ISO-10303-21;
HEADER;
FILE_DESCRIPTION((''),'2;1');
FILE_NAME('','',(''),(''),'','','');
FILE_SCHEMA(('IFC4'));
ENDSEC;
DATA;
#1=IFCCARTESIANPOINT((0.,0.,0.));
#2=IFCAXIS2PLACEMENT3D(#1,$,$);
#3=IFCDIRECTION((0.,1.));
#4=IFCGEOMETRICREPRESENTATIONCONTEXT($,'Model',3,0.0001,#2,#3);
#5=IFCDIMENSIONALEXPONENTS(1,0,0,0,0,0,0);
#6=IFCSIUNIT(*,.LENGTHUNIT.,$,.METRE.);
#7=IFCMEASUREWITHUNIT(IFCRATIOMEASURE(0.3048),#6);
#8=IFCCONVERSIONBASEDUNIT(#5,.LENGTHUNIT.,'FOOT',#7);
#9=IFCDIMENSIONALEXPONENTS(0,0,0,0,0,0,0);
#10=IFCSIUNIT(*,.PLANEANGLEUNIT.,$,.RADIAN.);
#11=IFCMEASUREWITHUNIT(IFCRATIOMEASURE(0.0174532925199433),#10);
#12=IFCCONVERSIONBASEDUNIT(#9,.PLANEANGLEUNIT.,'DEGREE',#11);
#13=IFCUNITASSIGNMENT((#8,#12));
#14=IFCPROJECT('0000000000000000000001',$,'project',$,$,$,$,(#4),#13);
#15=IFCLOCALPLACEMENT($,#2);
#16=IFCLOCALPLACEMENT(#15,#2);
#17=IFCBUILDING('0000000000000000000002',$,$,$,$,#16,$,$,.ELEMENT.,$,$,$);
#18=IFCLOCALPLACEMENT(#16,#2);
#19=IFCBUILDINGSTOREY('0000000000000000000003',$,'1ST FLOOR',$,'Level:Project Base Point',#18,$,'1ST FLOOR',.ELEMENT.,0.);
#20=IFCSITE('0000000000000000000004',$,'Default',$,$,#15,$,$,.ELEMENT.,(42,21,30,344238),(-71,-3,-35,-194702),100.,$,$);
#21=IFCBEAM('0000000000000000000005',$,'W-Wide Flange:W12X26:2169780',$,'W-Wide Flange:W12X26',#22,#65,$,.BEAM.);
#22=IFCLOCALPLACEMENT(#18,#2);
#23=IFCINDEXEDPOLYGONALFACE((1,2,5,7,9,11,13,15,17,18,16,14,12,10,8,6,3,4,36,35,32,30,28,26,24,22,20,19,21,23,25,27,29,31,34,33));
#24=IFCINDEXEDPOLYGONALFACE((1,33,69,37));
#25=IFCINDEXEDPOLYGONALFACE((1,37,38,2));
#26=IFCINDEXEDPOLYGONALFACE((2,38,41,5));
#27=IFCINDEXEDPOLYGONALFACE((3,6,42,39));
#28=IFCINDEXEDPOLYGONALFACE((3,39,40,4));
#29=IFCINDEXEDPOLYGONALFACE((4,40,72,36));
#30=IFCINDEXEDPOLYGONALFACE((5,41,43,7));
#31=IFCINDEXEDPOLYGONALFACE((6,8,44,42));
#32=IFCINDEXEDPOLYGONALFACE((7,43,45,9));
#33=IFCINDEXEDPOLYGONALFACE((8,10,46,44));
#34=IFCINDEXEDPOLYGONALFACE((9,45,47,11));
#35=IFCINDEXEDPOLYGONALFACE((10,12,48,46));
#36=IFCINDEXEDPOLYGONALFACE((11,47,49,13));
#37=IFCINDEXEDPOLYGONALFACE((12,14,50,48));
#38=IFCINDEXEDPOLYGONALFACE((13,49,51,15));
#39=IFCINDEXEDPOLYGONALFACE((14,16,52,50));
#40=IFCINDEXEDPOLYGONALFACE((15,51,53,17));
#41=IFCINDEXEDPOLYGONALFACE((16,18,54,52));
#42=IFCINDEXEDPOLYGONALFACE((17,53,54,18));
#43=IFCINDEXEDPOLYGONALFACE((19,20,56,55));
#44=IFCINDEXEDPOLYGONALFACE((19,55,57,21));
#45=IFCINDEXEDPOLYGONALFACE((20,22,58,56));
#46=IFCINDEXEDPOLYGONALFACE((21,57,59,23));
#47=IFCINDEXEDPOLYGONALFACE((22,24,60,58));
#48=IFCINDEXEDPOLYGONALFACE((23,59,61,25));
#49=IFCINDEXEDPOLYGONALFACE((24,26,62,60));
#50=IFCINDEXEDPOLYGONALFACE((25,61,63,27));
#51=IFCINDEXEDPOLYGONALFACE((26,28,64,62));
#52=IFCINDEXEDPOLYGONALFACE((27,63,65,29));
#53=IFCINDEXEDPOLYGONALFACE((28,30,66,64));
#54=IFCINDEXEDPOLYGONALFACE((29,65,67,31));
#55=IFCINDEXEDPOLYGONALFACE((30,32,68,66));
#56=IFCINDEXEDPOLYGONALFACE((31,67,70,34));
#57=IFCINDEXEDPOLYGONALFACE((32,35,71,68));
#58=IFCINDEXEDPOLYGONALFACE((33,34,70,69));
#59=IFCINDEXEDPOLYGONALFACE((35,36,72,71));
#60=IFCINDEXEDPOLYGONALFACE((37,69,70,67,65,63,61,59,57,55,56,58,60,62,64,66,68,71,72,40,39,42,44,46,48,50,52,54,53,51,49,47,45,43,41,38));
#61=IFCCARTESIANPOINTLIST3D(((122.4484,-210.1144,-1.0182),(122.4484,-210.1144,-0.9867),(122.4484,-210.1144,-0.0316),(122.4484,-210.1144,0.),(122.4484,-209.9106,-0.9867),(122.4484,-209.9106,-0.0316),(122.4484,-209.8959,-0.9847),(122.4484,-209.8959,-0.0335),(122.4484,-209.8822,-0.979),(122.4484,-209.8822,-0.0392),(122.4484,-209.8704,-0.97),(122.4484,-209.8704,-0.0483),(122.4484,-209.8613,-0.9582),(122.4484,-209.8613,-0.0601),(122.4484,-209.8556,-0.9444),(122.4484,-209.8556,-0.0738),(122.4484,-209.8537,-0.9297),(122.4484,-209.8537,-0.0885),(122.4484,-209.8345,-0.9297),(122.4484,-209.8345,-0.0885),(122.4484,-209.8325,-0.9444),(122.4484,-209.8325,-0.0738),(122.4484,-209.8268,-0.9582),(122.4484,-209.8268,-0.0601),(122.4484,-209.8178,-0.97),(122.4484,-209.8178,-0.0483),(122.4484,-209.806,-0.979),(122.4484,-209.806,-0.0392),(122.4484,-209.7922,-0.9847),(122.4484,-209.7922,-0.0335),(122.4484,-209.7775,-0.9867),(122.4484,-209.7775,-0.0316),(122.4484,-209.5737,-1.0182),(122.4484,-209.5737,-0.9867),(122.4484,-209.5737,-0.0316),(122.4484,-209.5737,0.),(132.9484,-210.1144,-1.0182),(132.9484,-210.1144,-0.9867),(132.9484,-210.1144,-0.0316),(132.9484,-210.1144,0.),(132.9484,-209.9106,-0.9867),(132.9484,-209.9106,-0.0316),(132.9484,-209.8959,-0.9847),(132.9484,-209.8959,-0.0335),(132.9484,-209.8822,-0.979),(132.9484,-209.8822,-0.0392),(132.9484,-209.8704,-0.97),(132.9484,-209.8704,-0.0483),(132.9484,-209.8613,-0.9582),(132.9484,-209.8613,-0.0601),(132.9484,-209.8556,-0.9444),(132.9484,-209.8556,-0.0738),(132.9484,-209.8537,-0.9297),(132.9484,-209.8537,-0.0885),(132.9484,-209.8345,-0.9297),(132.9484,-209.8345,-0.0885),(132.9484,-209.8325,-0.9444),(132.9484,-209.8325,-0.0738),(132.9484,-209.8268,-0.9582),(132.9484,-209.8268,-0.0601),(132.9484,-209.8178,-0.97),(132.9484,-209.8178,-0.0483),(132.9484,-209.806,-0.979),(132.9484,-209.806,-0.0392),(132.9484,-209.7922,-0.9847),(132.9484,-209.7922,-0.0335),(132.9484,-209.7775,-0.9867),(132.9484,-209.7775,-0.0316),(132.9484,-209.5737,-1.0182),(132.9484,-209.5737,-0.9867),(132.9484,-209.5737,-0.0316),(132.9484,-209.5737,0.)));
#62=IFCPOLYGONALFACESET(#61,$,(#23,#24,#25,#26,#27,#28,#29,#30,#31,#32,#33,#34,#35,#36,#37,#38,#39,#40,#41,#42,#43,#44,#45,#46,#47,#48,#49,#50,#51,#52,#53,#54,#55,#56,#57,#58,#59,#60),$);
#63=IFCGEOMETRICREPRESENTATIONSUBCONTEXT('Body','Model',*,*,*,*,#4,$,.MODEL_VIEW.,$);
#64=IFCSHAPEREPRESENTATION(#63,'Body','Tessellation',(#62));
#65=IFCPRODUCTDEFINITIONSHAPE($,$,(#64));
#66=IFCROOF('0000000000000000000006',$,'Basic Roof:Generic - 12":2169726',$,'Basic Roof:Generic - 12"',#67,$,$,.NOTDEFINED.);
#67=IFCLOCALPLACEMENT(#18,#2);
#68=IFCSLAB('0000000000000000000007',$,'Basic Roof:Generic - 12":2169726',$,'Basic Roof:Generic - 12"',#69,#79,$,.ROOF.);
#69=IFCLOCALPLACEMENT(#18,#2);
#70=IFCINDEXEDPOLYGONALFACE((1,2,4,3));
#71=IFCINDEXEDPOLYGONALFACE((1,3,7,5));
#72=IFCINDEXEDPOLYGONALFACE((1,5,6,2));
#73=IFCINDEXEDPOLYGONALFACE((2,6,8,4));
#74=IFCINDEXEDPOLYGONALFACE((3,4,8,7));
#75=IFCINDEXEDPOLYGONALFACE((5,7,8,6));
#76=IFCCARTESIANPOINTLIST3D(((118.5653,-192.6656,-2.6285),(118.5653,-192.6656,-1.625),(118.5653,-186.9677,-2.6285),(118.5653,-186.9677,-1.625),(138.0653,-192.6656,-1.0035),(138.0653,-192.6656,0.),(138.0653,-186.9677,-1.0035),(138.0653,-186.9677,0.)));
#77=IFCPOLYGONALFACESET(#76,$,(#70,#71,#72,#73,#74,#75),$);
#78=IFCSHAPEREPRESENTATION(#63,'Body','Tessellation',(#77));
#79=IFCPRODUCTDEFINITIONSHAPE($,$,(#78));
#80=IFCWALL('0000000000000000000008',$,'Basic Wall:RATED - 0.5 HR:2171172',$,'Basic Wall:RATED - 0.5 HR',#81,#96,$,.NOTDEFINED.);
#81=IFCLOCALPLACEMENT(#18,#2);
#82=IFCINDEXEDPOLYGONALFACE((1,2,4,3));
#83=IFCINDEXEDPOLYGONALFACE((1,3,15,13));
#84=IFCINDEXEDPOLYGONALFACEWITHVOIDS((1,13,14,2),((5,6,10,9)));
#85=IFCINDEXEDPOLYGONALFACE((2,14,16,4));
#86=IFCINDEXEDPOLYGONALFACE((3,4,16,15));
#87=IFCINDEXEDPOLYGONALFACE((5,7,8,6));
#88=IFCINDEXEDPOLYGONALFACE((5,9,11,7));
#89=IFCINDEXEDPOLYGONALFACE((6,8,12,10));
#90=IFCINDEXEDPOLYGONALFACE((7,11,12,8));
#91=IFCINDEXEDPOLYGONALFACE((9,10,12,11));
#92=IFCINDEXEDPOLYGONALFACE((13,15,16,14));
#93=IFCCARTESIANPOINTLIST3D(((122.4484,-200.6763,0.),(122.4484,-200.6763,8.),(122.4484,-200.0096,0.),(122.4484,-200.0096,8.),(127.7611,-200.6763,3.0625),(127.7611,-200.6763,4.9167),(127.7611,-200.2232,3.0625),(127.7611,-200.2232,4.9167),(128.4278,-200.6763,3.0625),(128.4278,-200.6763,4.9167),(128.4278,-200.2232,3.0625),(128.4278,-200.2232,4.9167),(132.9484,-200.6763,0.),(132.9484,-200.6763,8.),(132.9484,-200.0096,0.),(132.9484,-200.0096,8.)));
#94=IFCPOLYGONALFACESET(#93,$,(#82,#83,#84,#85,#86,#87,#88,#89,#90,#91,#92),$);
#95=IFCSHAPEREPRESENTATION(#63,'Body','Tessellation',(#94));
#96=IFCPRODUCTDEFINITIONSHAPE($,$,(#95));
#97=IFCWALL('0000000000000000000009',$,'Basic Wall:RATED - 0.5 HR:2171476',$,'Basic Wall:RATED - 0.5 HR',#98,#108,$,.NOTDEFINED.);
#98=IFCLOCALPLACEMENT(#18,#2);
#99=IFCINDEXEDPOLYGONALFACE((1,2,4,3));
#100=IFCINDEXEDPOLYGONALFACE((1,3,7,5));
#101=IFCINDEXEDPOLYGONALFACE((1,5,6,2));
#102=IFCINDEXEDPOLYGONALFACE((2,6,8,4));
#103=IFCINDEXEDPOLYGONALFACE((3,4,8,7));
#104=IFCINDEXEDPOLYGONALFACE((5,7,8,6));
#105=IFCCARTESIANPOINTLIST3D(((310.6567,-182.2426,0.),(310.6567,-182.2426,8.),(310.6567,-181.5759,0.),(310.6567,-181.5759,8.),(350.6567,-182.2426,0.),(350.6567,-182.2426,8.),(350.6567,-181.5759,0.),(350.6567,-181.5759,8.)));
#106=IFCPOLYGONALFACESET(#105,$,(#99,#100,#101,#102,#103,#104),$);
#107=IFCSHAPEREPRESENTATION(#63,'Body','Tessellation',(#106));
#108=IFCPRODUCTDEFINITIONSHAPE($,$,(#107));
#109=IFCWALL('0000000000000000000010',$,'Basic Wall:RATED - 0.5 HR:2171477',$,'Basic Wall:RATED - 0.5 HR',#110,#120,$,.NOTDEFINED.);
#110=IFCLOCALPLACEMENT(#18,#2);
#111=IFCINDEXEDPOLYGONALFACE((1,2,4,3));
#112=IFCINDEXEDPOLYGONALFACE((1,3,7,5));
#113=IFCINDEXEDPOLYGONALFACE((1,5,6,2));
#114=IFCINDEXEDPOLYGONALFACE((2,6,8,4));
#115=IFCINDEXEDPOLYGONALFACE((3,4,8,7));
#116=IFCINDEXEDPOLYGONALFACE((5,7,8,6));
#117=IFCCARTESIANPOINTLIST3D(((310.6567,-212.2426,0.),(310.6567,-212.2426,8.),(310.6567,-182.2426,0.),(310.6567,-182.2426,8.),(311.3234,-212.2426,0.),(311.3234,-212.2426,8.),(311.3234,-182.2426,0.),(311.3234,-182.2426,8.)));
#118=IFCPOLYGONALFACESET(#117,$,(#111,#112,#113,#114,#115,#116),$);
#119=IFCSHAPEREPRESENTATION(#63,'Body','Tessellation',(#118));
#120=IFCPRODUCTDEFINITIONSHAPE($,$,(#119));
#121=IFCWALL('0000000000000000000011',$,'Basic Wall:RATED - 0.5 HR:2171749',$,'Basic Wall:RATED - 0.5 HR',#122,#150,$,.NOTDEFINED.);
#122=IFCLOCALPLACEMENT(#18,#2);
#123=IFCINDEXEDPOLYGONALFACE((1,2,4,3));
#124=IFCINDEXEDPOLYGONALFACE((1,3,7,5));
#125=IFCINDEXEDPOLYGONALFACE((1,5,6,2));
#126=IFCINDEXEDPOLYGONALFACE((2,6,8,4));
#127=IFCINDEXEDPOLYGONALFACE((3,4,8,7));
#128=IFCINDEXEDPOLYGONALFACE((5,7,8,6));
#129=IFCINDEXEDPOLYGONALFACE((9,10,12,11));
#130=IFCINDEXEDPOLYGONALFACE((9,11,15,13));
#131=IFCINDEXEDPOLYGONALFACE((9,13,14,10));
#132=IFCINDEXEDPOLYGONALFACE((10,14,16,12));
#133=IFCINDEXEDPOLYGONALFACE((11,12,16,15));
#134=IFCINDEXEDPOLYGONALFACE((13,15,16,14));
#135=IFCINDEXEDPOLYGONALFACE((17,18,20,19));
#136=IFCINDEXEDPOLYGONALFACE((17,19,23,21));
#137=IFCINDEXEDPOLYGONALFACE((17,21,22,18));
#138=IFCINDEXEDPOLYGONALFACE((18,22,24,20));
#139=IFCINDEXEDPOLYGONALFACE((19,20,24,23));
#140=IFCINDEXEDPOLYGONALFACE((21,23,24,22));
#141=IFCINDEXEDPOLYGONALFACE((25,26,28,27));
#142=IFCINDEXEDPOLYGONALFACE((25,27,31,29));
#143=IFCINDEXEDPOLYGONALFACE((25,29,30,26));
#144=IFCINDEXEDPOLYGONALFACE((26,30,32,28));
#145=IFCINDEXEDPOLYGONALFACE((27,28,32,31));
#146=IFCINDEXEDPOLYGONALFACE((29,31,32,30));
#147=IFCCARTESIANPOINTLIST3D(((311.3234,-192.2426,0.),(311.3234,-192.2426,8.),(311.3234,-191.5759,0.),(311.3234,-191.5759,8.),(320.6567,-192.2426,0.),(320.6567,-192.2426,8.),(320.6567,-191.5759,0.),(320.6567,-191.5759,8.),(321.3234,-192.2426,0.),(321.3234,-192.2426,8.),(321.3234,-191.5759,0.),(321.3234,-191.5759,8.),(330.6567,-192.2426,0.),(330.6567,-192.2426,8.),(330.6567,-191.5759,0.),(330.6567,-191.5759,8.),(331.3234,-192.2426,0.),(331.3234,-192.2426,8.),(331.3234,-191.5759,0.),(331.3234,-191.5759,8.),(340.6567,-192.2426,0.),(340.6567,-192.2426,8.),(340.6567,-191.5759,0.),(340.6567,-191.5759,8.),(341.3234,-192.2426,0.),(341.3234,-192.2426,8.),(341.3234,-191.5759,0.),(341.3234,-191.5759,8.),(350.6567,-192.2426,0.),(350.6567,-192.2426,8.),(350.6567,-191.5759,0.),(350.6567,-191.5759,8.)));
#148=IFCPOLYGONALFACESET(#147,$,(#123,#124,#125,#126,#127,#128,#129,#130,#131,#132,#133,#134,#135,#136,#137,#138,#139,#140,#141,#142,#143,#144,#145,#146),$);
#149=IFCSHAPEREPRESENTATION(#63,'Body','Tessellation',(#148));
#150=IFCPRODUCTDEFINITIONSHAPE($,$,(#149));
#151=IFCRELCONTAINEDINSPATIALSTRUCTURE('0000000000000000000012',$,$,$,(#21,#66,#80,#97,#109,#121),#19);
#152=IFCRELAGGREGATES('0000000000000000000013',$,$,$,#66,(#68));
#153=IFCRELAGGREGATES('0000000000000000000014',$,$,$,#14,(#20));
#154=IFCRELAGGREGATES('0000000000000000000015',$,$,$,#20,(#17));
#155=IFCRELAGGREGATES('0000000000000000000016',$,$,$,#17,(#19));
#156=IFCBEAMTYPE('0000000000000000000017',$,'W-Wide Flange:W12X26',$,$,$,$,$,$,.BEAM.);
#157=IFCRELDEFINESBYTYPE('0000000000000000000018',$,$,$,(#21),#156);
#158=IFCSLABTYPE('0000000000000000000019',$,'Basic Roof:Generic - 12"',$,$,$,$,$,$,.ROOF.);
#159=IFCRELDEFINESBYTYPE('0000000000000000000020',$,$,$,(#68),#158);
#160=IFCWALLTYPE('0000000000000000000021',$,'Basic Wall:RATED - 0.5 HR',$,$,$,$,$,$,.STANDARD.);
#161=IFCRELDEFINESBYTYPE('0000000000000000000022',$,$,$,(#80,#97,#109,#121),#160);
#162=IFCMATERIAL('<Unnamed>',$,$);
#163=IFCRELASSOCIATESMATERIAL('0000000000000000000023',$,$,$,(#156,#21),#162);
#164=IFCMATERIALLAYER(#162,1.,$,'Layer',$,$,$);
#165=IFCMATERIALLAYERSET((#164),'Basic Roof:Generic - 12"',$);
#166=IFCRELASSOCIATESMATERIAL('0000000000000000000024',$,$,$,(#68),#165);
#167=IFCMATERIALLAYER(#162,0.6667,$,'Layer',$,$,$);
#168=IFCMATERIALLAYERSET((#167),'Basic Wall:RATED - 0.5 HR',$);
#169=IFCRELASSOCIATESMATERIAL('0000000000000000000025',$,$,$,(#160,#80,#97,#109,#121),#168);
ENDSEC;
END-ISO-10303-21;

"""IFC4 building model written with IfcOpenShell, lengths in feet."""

from ifc_helpers import new_model, entity, si_unit, converted_unit, direction, frame, frame_2d, origin, place, context, subcontext, project, spatial, rectangle, i_section, extrude, source, transform, mapped, material, layer, layer_set, layer_usage, material_profile, profile_set, profile_usage, type_object, type_shapes, element, aggregate, save


model = new_model("IFC4")

# Units and contexts
model_context = context("Model", 3, precision=0.0001, world=origin(), true_north=direction((0.0, 1.0)))
body_context = subcontext(model_context, "Body", "Model", "MODEL_VIEW")
ifc_project = project(units=[converted_unit("LENGTHUNIT", "FOOT", entity("IfcRatioMeasure", 0.3048), si_unit("LENGTHUNIT", "METRE"), dimensions=[1, 0, 0, 0, 0, 0, 0]), converted_unit("PLANEANGLEUNIT", "DEGREE", entity("IfcRatioMeasure", 0.0174532925199433), si_unit("PLANEANGLEUNIT", "RADIAN"), dimensions=[0, 0, 0, 0, 0, 0, 0])], contexts=[model_context])

# Site, building, storey
site_placement = place(None, origin())
site = spatial("IfcSite", under=ifc_project, at=site_placement, Name="Default", CompositionType="ELEMENT", RefLatitude=(42, 21, 30, 344238), RefLongitude=(-71, -3, -35, -194702), RefElevation=100.0)
building_placement = place(site_placement, origin())
building = spatial("IfcBuilding", under=site, at=building_placement, CompositionType="ELEMENT")
storey_placement = place(building_placement, origin())
storey = spatial("IfcBuildingStorey", under=building, at=storey_placement, Name="1ST FLOOR", ObjectType="Level:Project Base Point", LongName="1ST FLOOR", CompositionType="ELEMENT", Elevation=0.0)

# Beam
ifc_material_1 = material(Name="<Unnamed>")
ifc_material_profile = material_profile(ifc_material_1, i_section(OverallWidth=0.5407, OverallDepth=1.0182, WebThickness=0.0192, FlangeThickness=0.0316, FilletRadius=0.057, at=frame_2d((0.0, 0.0), x_axis=(0.0, 1.0))), Name="W12X26")
ifc_profile_set = profile_set([ifc_material_profile], Name="W12X26")
ifc_profile_usage = profile_usage(ifc_profile_set, cardinal=8)
beam_type = type_object("IfcBeamType", Name="W-Wide Flange:W12X26", PredefinedType="BEAM", material=ifc_profile_set)
shared_shape_1 = source(origin(), body_context, "Body", "SweptSolid", [
    extrude(i_section(OverallWidth=0.5407, OverallDepth=1.0182, WebThickness=0.0192, FlangeThickness=0.0316, FilletRadius=0.057, at=frame_2d((0.0, 0.0), x_axis=(0.0, 1.0))), frame((-5.25, 0.0, 0.0), z_axis=(1.0, 0.0, 0.0), x_axis=(0.0, 0.0, -1.0)), (0.0, 0.0, 1.0), 10.5),
])
type_shapes(beam_type, [shared_shape_1])
beam_placement = place(storey_placement, frame((127.6984, -209.8441, -0.5091)))
element("IfcBeam", 1, at=beam_placement, inside=storey, type_object=beam_type, material=ifc_profile_usage, Name="W-Wide Flange:W12X26:2169780", ObjectType="W-Wide Flange:W12X26", PredefinedType="BEAM", context=body_context, shape_type="MappedRepresentation", body=[
    mapped(shared_shape_1, transform((0.0, 0.0, 0.0), scale=1.0)),
])

# Roof, slab
roof_placement = place(storey_placement, frame((118.5653, -192.6656, -2.6285)))
roof = element("IfcRoof", 2, at=roof_placement, inside=storey, Name="Basic Roof:Generic - 12\":2169726", ObjectType="Basic Roof:Generic - 12\"", PredefinedType="NOTDEFINED")
ifc_layer_1 = layer(ifc_material_1, 1.0, Name="Layer")
ifc_layer_set_1 = layer_set([ifc_layer_1], Name="Basic Roof:Generic - 12\"")
slab_type = type_object("IfcSlabType", Name="Basic Roof:Generic - 12\"", PredefinedType="ROOF")
slab_placement = place(roof_placement, origin())
slab = element("IfcSlab", 3, at=slab_placement, type_object=slab_type, material=ifc_layer_set_1, Name="Basic Roof:Generic - 12\":2169726", ObjectType="Basic Roof:Generic - 12\"", PredefinedType="ROOF", context=body_context, shape_type="SweptSolid", body=[
    extrude(rectangle(XDim=19.5676, YDim=5.6979, at=frame_2d((0.0, 0.0), x_axis=(1.0, 0.0))), frame((9.75, 2.849, 0.8125), z_axis=(-0.083045, 0.0, 0.996546), x_axis=(0.996546, 0.0, 0.083045)), (0.083045, 0.0, 0.996546), 1.0035),
])
aggregate(roof, [slab])

# Wall, opening
ifc_layer_2 = layer(ifc_material_1, 0.6667, Name="Layer")
ifc_layer_set_2 = layer_set([ifc_layer_2], Name="Basic Wall:RATED - 0.5 HR")
ifc_layer_usage_1 = layer_usage(ifc_layer_set_2, "AXIS2", "NEGATIVE", 0.3333)
wall_type_1 = type_object("IfcWallType", Name="Basic Wall:RATED - 0.5 HR", PredefinedType="STANDARD", material=ifc_layer_set_2)
wall_1_placement = place(storey_placement, frame((122.4484, -200.3429, 0.0)))
wall_1 = element("IfcWall", 4, at=wall_1_placement, inside=storey, type_object=wall_type_1, material=ifc_layer_usage_1, Name="Basic Wall:RATED - 0.5 HR:2171172", ObjectType="Basic Wall:RATED - 0.5 HR", PredefinedType="NOTDEFINED", context=body_context, shape_type="SweptSolid", body=[
    extrude(rectangle(XDim=10.5, YDim=0.6667, at=frame_2d((5.25, 0.0), x_axis=(-1.0, 0.0))), origin(), (0.0, 0.0, 1.0), 8.0),
])
opening_1_placement = place(wall_1_placement, frame((5.3127, -0.3542, 3.0625)))
element("IfcOpeningElement", 5, at=opening_1_placement, cuts=wall_1, PredefinedType="RECESS", context=body_context, shape_type="SweptSolid", body=[
    extrude(rectangle(XDim=1.8542, YDim=0.6667, at=frame_2d((0.0, 0.0), x_axis=(1.0, 0.0))), frame((0.3333, 0.0, 0.9271), z_axis=(0.0, 1.0, 0.0), x_axis=(0.0, 0.0, -1.0)), (0.0, 0.0, 1.0), 0.474),
])

# Walls
ifc_layer_usage_2 = layer_usage(ifc_layer_set_2, "AXIS2", "NEGATIVE", 0.3333)
wall_2_placement = place(storey_placement, frame((310.6567, -181.9092, 0.0)))
element("IfcWall", 6, at=wall_2_placement, inside=storey, type_object=wall_type_1, material=ifc_layer_usage_2, Name="Basic Wall:RATED - 0.5 HR:2171476", ObjectType="Basic Wall:RATED - 0.5 HR", PredefinedType="NOTDEFINED", context=body_context, shape_type="SweptSolid", body=[
    extrude(rectangle(XDim=40.0, YDim=0.6667, at=frame_2d((20.0, 0.0), x_axis=(-1.0, 0.0))), origin(), (0.0, 0.0, 1.0), 8.0),
])
ifc_layer_usage_3 = layer_usage(ifc_layer_set_2, "AXIS2", "NEGATIVE", 0.3333)
wall_3_placement = place(storey_placement, frame((310.9901, -212.2426, 0.0), z_axis=(0.0, 0.0, 1.0), x_axis=(0.0, 1.0, 0.0)))
element("IfcWall", 7, at=wall_3_placement, inside=storey, type_object=wall_type_1, material=ifc_layer_usage_3, Name="Basic Wall:RATED - 0.5 HR:2171477", ObjectType="Basic Wall:RATED - 0.5 HR", PredefinedType="NOTDEFINED", context=body_context, shape_type="SweptSolid", body=[
    extrude(rectangle(XDim=30.0, YDim=0.6667, at=frame_2d((15.0, 0.0), x_axis=(-1.0, 0.0))), origin(), (0.0, 0.0, 1.0), 8.0),
])

# Wall, openings
ifc_layer_usage_4 = layer_usage(ifc_layer_set_2, "AXIS2", "NEGATIVE", 0.3333)
wall_4_placement = place(storey_placement, frame((311.3234, -191.9092, 0.0)))
wall_4 = element("IfcWall", 8, at=wall_4_placement, inside=storey, type_object=wall_type_1, material=ifc_layer_usage_4, Name="Basic Wall:RATED - 0.5 HR:2171749", ObjectType="Basic Wall:RATED - 0.5 HR", PredefinedType="NOTDEFINED", context=body_context, shape_type="SweptSolid", body=[
    extrude(rectangle(XDim=39.3333, YDim=0.6667, at=frame_2d((19.6667, 0.0), x_axis=(-1.0, 0.0))), origin(), (0.0, 0.0, 1.0), 8.0),
])
opening_2_placement = place(storey_placement, frame((311.3234, -191.9092, 0.0)))
element("IfcOpeningElement", 9, at=opening_2_placement, cuts=wall_4, PredefinedType="OPENING", context=body_context, shape_type="SweptSolid", body=[
    extrude(rectangle(XDim=8.0, YDim=0.6667, at=frame_2d((0.0, 0.0), x_axis=(1.0, 0.0))), frame((29.3333, 0.0, 4.0), z_axis=(1.0, 0.0, 0.0), x_axis=(0.0, 0.0, -1.0)), (0.0, 0.0, 1.0), 0.6667),
])
opening_3_placement = place(storey_placement, frame((311.3234, -191.9092, 0.0)))
element("IfcOpeningElement", 10, at=opening_3_placement, cuts=wall_4, PredefinedType="OPENING", context=body_context, shape_type="SweptSolid", body=[
    extrude(rectangle(XDim=8.0, YDim=0.6667, at=frame_2d((0.0, 0.0), x_axis=(1.0, 0.0))), frame((19.3333, 0.0, 4.0), z_axis=(1.0, 0.0, 0.0), x_axis=(0.0, 0.0, -1.0)), (0.0, 0.0, 1.0), 0.6667),
])
opening_4_placement = place(storey_placement, frame((311.3234, -191.9092, 0.0)))
element("IfcOpeningElement", 11, at=opening_4_placement, cuts=wall_4, PredefinedType="OPENING", context=body_context, shape_type="SweptSolid", body=[
    extrude(rectangle(XDim=8.0, YDim=0.6667, at=frame_2d((0.0, 0.0), x_axis=(1.0, 0.0))), frame((9.3333, 0.0, 4.0), z_axis=(1.0, 0.0, 0.0), x_axis=(0.0, 0.0, -1.0)), (0.0, 0.0, 1.0), 0.6667),
])

save(model, "model.ifc")
